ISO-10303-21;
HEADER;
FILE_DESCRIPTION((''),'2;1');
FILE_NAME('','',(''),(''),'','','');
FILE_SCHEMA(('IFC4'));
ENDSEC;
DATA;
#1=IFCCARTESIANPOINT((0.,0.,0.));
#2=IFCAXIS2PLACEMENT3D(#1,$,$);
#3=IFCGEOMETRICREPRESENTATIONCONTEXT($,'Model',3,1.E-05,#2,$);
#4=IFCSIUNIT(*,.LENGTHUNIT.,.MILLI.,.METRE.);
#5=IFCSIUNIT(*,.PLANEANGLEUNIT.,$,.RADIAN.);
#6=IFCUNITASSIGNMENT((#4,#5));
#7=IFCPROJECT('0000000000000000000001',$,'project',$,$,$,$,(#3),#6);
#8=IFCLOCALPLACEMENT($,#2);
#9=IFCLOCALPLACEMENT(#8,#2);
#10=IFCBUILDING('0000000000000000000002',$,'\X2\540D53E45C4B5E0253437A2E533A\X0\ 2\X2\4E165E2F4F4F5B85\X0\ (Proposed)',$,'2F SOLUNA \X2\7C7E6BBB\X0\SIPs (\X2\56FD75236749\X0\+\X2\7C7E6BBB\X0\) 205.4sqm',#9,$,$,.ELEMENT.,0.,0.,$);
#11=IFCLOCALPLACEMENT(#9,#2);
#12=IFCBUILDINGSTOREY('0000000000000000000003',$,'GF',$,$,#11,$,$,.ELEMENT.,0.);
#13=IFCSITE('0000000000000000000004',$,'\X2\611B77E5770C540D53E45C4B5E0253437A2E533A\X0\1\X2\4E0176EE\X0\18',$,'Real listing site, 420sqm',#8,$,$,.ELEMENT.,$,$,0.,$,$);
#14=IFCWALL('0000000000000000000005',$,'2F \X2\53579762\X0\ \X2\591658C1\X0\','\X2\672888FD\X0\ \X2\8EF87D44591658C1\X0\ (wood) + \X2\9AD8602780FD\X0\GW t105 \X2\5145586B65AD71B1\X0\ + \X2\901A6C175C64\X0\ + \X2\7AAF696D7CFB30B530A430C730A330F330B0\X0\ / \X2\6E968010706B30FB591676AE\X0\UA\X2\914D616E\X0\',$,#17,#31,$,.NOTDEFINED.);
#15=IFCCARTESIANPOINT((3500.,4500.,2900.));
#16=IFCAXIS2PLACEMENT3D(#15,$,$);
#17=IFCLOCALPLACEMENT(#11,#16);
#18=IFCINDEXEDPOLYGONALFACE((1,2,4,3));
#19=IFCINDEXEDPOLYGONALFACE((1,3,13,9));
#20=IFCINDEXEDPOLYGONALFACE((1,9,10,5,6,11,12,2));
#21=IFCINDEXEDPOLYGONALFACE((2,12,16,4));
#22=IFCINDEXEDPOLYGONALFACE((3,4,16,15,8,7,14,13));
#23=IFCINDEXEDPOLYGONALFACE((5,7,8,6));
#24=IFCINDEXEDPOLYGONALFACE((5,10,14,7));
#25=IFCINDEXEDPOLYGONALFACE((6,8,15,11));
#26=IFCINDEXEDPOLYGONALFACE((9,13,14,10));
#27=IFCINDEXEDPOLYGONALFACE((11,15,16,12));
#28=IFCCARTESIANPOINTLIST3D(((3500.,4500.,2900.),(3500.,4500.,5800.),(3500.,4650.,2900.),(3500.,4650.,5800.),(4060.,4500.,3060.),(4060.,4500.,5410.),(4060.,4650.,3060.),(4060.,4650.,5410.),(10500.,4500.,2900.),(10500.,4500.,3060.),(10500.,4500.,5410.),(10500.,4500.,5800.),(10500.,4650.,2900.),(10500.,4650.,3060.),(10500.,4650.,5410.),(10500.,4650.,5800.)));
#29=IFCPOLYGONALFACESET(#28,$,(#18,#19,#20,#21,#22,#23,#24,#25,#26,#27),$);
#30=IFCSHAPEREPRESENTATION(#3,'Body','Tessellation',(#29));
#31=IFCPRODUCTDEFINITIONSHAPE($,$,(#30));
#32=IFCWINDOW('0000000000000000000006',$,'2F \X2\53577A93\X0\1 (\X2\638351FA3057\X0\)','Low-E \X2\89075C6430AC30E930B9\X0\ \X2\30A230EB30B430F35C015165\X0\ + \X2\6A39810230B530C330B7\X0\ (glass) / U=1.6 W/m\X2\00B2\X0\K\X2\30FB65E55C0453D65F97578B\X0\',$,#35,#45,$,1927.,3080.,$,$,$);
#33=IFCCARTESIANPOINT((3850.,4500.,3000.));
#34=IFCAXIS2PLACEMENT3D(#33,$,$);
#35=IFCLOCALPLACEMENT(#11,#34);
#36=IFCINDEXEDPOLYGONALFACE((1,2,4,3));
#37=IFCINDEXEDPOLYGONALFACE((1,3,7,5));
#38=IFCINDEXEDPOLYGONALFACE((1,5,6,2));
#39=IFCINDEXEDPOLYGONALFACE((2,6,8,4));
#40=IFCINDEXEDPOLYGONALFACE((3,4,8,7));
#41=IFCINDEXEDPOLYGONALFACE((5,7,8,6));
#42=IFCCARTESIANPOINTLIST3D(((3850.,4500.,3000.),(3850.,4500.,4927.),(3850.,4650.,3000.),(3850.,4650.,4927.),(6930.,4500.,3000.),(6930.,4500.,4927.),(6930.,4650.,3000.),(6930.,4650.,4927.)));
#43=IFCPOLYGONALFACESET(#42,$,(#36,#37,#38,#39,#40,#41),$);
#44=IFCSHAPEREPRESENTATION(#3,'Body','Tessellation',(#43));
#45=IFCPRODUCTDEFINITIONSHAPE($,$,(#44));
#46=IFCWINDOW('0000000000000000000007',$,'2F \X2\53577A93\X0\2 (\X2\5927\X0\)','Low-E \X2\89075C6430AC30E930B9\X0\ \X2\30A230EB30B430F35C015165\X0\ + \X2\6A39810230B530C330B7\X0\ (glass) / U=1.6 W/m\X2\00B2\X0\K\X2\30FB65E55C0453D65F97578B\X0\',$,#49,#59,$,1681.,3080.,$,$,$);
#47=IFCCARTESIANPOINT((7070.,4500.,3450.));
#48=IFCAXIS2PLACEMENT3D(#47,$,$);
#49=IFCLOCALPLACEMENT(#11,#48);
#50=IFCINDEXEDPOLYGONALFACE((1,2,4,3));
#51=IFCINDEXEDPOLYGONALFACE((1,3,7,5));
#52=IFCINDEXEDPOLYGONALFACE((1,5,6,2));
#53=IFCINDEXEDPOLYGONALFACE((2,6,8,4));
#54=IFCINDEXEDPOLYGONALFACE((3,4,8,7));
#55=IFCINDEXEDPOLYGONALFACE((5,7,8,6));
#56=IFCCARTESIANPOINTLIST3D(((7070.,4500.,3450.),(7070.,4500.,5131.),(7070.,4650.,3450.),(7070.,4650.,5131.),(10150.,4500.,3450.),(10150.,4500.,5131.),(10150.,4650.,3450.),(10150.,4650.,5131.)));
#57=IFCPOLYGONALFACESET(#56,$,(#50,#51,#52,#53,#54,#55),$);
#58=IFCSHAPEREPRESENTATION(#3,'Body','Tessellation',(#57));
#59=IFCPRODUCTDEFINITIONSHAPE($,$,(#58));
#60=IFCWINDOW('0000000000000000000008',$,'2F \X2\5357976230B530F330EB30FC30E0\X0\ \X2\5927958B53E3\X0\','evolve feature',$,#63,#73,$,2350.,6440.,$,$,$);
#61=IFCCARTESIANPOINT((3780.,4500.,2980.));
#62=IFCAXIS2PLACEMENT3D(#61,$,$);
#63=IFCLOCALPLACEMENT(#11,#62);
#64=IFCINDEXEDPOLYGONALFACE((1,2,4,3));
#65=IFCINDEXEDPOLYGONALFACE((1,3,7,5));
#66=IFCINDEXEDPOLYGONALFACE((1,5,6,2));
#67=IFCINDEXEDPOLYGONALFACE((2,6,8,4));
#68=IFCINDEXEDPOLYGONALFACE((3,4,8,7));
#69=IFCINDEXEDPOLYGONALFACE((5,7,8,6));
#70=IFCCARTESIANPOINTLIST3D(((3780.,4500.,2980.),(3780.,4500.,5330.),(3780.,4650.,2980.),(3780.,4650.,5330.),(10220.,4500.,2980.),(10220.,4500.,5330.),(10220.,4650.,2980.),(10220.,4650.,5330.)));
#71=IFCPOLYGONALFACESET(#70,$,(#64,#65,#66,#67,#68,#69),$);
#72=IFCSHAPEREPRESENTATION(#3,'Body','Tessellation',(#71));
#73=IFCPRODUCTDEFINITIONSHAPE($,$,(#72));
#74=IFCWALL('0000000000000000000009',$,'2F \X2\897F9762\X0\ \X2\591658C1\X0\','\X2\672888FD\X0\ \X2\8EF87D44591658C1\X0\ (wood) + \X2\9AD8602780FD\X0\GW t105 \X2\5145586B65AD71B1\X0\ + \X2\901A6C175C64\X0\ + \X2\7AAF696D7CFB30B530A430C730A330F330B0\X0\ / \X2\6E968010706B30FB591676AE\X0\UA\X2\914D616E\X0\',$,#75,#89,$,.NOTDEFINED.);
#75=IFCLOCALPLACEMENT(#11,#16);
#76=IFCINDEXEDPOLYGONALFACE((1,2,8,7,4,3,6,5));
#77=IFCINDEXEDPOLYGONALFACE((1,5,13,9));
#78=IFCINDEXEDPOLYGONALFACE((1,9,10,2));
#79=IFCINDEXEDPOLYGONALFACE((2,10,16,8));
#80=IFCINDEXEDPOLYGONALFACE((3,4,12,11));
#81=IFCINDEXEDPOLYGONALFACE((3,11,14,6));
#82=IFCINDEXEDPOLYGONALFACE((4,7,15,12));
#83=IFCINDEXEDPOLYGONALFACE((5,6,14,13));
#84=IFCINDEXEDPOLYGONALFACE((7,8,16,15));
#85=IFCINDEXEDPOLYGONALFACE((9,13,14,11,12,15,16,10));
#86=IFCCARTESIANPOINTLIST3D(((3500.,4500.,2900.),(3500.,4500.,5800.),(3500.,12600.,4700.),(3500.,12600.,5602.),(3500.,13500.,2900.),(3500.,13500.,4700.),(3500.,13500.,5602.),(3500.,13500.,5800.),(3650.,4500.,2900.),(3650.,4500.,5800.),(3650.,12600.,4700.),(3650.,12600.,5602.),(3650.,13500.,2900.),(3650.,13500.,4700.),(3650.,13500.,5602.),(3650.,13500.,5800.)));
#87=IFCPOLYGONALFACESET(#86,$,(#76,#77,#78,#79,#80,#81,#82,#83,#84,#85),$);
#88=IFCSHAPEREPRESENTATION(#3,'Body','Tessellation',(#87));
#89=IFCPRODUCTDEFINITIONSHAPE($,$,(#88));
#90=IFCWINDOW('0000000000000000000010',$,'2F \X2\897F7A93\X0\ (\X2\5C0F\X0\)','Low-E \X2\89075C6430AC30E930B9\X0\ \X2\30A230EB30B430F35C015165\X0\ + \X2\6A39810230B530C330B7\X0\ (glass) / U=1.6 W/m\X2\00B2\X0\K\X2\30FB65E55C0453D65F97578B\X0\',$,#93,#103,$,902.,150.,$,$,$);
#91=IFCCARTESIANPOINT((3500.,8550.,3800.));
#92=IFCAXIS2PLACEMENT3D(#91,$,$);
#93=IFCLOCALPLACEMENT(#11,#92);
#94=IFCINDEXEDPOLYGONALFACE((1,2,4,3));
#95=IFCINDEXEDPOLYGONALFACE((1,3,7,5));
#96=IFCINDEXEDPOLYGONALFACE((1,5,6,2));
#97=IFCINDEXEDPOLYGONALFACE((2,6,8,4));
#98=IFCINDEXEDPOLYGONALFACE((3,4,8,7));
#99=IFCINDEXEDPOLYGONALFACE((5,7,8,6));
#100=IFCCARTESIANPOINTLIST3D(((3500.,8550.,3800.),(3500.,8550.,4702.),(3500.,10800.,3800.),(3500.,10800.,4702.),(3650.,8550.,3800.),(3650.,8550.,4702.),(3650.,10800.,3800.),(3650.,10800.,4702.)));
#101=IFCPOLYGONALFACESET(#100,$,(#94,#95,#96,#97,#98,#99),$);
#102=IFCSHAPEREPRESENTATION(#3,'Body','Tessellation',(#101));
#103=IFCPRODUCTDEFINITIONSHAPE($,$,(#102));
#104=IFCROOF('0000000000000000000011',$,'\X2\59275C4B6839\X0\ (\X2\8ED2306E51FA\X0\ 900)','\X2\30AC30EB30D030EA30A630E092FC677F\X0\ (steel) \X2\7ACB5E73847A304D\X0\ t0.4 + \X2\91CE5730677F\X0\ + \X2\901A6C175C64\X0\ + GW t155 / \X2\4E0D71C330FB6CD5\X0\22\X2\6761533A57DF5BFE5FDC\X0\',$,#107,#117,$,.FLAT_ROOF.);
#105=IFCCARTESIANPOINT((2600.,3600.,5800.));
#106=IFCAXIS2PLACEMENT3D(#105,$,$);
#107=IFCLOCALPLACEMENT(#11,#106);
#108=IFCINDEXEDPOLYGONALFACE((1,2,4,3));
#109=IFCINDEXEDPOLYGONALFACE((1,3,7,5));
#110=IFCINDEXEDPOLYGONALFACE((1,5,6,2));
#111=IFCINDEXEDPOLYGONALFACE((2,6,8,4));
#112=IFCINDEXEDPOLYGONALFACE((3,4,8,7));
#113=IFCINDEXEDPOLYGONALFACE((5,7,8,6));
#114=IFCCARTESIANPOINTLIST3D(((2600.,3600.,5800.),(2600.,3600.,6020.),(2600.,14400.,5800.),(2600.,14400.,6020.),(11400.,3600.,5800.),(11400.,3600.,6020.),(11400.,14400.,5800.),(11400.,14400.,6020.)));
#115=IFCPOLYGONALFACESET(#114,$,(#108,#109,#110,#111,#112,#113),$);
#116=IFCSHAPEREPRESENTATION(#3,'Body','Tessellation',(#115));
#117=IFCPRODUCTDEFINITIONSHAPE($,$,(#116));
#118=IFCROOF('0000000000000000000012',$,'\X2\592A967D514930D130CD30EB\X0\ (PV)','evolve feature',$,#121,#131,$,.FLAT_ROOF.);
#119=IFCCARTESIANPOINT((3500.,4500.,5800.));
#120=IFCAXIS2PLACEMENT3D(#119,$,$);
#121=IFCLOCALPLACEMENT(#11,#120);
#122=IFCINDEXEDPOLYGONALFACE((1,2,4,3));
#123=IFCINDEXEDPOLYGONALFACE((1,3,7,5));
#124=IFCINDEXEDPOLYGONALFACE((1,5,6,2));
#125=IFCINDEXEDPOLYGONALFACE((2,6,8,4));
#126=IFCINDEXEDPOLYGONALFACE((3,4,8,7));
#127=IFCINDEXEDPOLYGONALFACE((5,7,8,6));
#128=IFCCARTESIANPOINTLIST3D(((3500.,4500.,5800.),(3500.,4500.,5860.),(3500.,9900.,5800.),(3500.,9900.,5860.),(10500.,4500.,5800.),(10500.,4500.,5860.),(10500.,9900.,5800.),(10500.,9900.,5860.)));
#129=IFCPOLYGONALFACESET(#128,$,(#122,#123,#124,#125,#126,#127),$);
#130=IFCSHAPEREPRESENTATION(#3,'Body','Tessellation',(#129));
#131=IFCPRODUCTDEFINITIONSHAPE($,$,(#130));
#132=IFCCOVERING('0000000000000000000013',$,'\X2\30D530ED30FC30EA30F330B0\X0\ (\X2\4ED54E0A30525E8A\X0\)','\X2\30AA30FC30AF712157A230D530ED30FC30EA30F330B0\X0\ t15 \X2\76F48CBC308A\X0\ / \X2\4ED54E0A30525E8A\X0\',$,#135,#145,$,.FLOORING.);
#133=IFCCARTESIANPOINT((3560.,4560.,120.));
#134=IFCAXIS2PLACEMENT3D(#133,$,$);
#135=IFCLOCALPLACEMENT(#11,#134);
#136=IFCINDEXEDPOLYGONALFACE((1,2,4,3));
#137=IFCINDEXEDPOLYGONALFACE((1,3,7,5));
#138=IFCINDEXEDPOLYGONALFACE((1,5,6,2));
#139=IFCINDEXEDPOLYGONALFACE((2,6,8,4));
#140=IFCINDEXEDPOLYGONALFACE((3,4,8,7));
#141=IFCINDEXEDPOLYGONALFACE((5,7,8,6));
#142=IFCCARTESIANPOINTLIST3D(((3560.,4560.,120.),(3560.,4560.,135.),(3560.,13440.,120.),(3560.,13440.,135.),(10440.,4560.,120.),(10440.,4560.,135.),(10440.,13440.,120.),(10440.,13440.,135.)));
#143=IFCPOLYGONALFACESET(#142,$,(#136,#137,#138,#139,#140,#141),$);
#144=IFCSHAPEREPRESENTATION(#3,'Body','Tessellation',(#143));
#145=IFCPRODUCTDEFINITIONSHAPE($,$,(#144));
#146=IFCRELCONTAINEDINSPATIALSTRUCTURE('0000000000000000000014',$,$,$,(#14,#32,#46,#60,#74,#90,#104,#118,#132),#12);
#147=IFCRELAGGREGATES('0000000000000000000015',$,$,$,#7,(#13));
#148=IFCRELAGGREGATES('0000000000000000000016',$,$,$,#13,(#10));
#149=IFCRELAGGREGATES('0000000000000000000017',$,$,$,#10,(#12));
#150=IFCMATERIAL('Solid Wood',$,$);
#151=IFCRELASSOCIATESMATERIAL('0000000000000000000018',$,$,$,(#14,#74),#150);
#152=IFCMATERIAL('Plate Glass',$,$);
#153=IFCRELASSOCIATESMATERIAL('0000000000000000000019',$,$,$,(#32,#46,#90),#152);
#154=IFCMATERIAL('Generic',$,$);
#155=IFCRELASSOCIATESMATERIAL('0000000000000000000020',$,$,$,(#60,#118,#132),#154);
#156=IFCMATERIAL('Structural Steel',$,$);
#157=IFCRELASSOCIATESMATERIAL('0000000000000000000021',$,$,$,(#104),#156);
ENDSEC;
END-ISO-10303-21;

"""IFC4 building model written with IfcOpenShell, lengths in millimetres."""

from ifc_helpers import new_model, si_unit, frame, frame_2d, origin, place, context, project, spatial, rectangle, extrude, material, element, fill, save


model = new_model("IFC4")

# Units and contexts
model_context = context("Model", 3, precision=1e-05, world=origin())
ifc_project = project(units=[si_unit("LENGTHUNIT", "METRE", prefix="MILLI"), si_unit("PLANEANGLEUNIT", "RADIAN")], contexts=[model_context])

# Site, building, storey
site_placement = place(None, origin())
site = spatial("IfcSite", under=ifc_project, at=site_placement, Name="愛知県名古屋市千種区1丁目18", ObjectType="Real listing site, 420sqm", CompositionType="ELEMENT", RefElevation=0.0)
building_placement = place(site_placement, origin())
building = spatial("IfcBuilding", under=site, at=building_placement, Name="名古屋市千種区 2世帯住宅 (Proposed)", ObjectType="2F SOLUNA 籾殻SIPs (国産杉+籾殻) 205.4sqm", CompositionType="ELEMENT", ElevationOfRefHeight=0.0, ElevationOfTerrain=0.0)
storey_placement = place(building_placement, origin())
storey = spatial("IfcBuildingStorey", under=building, at=storey_placement, Name="GF", CompositionType="ELEMENT", Elevation=0.0)

# Shared definitions
ifc_material_1 = material(Name="Solid Wood")
ifc_material_2 = material(Name="Generic")

# Shared definitions
ifc_material_3 = material(Name="Plate Glass")

# Wall, openings, windows
wall_1_placement = place(storey_placement, frame((3500.0, 4500.0, 2900.0)))
wall_1 = element("IfcWall", 1, at=wall_1_placement, inside=storey, material=ifc_material_1, Name="2F 南面 外壁", Description="木製 軸組外壁 (wood) + 高性能GW t105 充填断熱 + 通気層 + 窯業系サイディング / 準耐火・外皮UA配慮", PredefinedType="NOTDEFINED", context=model_context, shape_type="SweptSolid", body=[
    extrude(rectangle(XDim=7000.0, YDim=150.0, at=frame_2d((3500.0, 75.0))), frame((3500.0, 4500.0, 2900.0)), (0.0, 0.0, 1.0), 2900.0),
])
opening_1_placement = place(storey_placement, frame((3850.0, 4500.0, 3000.0)))
opening_1 = element("IfcOpeningElement", 2, at=opening_1_placement, cuts=wall_1, PredefinedType="NOTDEFINED", context=model_context, shape_type="SweptSolid", body=[
    extrude(rectangle(XDim=3080.0, YDim=150.0, at=frame_2d((1540.0, 75.0))), frame((3850.0, 4500.0, 3000.0)), (0.0, 0.0, 1.0), 1927.0),
])
opening_2_placement = place(storey_placement, frame((7070.0, 4500.0, 3450.0)))
opening_2 = element("IfcOpeningElement", 3, at=opening_2_placement, cuts=wall_1, PredefinedType="NOTDEFINED", context=model_context, shape_type="SweptSolid", body=[
    extrude(rectangle(XDim=3080.0, YDim=150.0, at=frame_2d((1540.0, 75.0))), frame((7070.0, 4500.0, 3450.0)), (0.0, 0.0, 1.0), 1681.0),
])
opening_3_placement = place(storey_placement, frame((3780.0, 4500.0, 2980.0)))
opening_3 = element("IfcOpeningElement", 4, at=opening_3_placement, cuts=wall_1, PredefinedType="NOTDEFINED", context=model_context, shape_type="SweptSolid", body=[
    extrude(rectangle(XDim=6440.0, YDim=150.0, at=frame_2d((3220.0, 75.0))), frame((3780.0, 4500.0, 2980.0)), (0.0, 0.0, 1.0), 2350.0),
])
window_1_placement = place(storey_placement, frame((3850.0, 4500.0, 3000.0)))
window_1 = element("IfcWindow", 5, at=window_1_placement, inside=storey, material=ifc_material_3, Name="2F 南窓1 (掃出し)", Description="Low-E 複層ガラス アルゴン封入 + 樹脂サッシ (glass) / U=1.6 W/m²K・日射取得型", OverallHeight=1927.0, OverallWidth=3080.0, context=model_context, shape_type="SweptSolid", body=[
    extrude(rectangle(XDim=3080.0, YDim=150.0, at=frame_2d((1540.0, 75.0))), frame((3850.0, 4500.0, 3000.0)), (0.0, 0.0, 1.0), 1927.0),
])
fill(opening_1, window_1)
window_2_placement = place(storey_placement, frame((7070.0, 4500.0, 3450.0)))
window_2 = element("IfcWindow", 6, at=window_2_placement, inside=storey, material=ifc_material_3, Name="2F 南窓2 (大)", Description="Low-E 複層ガラス アルゴン封入 + 樹脂サッシ (glass) / U=1.6 W/m²K・日射取得型", OverallHeight=1681.0, OverallWidth=3080.0, context=model_context, shape_type="SweptSolid", body=[
    extrude(rectangle(XDim=3080.0, YDim=150.0, at=frame_2d((1540.0, 75.0))), frame((7070.0, 4500.0, 3450.0)), (0.0, 0.0, 1.0), 1681.0),
])
fill(opening_2, window_2)
window_3_placement = place(storey_placement, frame((3780.0, 4500.0, 2980.0)))
window_3 = element("IfcWindow", 7, at=window_3_placement, inside=storey, material=ifc_material_2, Name="2F 南面サンルーム 大開口", Description="evolve feature", OverallHeight=2350.0, OverallWidth=6440.0, context=model_context, shape_type="SweptSolid", body=[
    extrude(rectangle(XDim=6440.0, YDim=150.0, at=frame_2d((3220.0, 75.0))), frame((3780.0, 4500.0, 2980.0)), (0.0, 0.0, 1.0), 2350.0),
])
fill(opening_3, window_3)

# Wall, opening, window
wall_2_placement = place(storey_placement, frame((3500.0, 4500.0, 2900.0)))
wall_2 = element("IfcWall", 8, at=wall_2_placement, inside=storey, material=ifc_material_1, Name="2F 西面 外壁", Description="木製 軸組外壁 (wood) + 高性能GW t105 充填断熱 + 通気層 + 窯業系サイディング / 準耐火・外皮UA配慮", PredefinedType="NOTDEFINED", context=model_context, shape_type="SweptSolid", body=[
    extrude(rectangle(XDim=150.0, YDim=9000.0, at=frame_2d((75.0, 4500.0))), frame((3500.0, 4500.0, 2900.0)), (0.0, 0.0, 1.0), 2900.0),
])
opening_4_placement = place(storey_placement, frame((3500.0, 8550.0, 3800.0)))
opening_4 = element("IfcOpeningElement", 9, at=opening_4_placement, cuts=wall_2, PredefinedType="NOTDEFINED", context=model_context, shape_type="SweptSolid", body=[
    extrude(rectangle(XDim=150.0, YDim=2250.0, at=frame_2d((75.0, 1125.0))), frame((3500.0, 8550.0, 3800.0)), (0.0, 0.0, 1.0), 902.0),
])
window_4_placement = place(storey_placement, frame((3500.0, 8550.0, 3800.0)))
window_4 = element("IfcWindow", 10, at=window_4_placement, inside=storey, material=ifc_material_3, Name="2F 西窓 (小)", Description="Low-E 複層ガラス アルゴン封入 + 樹脂サッシ (glass) / U=1.6 W/m²K・日射取得型", OverallHeight=902.0, OverallWidth=150.0, context=model_context, shape_type="SweptSolid", body=[
    extrude(rectangle(XDim=150.0, YDim=2250.0, at=frame_2d((75.0, 1125.0))), frame((3500.0, 8550.0, 3800.0)), (0.0, 0.0, 1.0), 902.0),
])
fill(opening_4, window_4)

# Roofs
ifc_material_4 = material(Name="Structural Steel")
roof_1_placement = place(storey_placement, frame((2600.0, 3600.0, 5800.0)))
element("IfcRoof", 11, at=roof_1_placement, inside=storey, material=ifc_material_4, Name="大屋根 (軒の出 900)", Description="ガルバリウム鋼板 (steel) 立平葺き t0.4 + 野地板 + 通気層 + GW t155 / 不燃・法22条区域対応", PredefinedType="FLAT_ROOF", context=model_context, shape_type="SweptSolid", body=[
    extrude(rectangle(XDim=8800.0, YDim=10800.0, at=frame_2d((4400.0, 5400.0))), frame((2600.0, 3600.0, 5800.0)), (0.0, 0.0, 1.0), 220.0),
])
roof_2_placement = place(storey_placement, frame((3500.0, 4500.0, 5800.0)))
element("IfcRoof", 12, at=roof_2_placement, inside=storey, material=ifc_material_2, Name="太陽光パネル (PV)", Description="evolve feature", PredefinedType="FLAT_ROOF", context=model_context, shape_type="SweptSolid", body=[
    extrude(rectangle(XDim=7000.0, YDim=5400.0, at=frame_2d((3500.0, 2700.0))), frame((3500.0, 4500.0, 5800.0)), (0.0, 0.0, 1.0), 60.0),
])

# Covering
covering_placement = place(storey_placement, frame((3560.0, 4560.0, 120.0)))
element("IfcCovering", 13, at=covering_placement, inside=storey, material=ifc_material_2, Name="フローリング (仕上げ床)", Description="オーク無垢フローリング t15 直貼り / 仕上げ床", PredefinedType="FLOORING", context=model_context, shape_type="SweptSolid", body=[
    extrude(rectangle(XDim=6880.0, YDim=8880.0, at=frame_2d((3440.0, 4440.0))), frame((3560.0, 4560.0, 120.0)), (0.0, 0.0, 1.0), 15.0),
])

save(model, "model.ifc")
